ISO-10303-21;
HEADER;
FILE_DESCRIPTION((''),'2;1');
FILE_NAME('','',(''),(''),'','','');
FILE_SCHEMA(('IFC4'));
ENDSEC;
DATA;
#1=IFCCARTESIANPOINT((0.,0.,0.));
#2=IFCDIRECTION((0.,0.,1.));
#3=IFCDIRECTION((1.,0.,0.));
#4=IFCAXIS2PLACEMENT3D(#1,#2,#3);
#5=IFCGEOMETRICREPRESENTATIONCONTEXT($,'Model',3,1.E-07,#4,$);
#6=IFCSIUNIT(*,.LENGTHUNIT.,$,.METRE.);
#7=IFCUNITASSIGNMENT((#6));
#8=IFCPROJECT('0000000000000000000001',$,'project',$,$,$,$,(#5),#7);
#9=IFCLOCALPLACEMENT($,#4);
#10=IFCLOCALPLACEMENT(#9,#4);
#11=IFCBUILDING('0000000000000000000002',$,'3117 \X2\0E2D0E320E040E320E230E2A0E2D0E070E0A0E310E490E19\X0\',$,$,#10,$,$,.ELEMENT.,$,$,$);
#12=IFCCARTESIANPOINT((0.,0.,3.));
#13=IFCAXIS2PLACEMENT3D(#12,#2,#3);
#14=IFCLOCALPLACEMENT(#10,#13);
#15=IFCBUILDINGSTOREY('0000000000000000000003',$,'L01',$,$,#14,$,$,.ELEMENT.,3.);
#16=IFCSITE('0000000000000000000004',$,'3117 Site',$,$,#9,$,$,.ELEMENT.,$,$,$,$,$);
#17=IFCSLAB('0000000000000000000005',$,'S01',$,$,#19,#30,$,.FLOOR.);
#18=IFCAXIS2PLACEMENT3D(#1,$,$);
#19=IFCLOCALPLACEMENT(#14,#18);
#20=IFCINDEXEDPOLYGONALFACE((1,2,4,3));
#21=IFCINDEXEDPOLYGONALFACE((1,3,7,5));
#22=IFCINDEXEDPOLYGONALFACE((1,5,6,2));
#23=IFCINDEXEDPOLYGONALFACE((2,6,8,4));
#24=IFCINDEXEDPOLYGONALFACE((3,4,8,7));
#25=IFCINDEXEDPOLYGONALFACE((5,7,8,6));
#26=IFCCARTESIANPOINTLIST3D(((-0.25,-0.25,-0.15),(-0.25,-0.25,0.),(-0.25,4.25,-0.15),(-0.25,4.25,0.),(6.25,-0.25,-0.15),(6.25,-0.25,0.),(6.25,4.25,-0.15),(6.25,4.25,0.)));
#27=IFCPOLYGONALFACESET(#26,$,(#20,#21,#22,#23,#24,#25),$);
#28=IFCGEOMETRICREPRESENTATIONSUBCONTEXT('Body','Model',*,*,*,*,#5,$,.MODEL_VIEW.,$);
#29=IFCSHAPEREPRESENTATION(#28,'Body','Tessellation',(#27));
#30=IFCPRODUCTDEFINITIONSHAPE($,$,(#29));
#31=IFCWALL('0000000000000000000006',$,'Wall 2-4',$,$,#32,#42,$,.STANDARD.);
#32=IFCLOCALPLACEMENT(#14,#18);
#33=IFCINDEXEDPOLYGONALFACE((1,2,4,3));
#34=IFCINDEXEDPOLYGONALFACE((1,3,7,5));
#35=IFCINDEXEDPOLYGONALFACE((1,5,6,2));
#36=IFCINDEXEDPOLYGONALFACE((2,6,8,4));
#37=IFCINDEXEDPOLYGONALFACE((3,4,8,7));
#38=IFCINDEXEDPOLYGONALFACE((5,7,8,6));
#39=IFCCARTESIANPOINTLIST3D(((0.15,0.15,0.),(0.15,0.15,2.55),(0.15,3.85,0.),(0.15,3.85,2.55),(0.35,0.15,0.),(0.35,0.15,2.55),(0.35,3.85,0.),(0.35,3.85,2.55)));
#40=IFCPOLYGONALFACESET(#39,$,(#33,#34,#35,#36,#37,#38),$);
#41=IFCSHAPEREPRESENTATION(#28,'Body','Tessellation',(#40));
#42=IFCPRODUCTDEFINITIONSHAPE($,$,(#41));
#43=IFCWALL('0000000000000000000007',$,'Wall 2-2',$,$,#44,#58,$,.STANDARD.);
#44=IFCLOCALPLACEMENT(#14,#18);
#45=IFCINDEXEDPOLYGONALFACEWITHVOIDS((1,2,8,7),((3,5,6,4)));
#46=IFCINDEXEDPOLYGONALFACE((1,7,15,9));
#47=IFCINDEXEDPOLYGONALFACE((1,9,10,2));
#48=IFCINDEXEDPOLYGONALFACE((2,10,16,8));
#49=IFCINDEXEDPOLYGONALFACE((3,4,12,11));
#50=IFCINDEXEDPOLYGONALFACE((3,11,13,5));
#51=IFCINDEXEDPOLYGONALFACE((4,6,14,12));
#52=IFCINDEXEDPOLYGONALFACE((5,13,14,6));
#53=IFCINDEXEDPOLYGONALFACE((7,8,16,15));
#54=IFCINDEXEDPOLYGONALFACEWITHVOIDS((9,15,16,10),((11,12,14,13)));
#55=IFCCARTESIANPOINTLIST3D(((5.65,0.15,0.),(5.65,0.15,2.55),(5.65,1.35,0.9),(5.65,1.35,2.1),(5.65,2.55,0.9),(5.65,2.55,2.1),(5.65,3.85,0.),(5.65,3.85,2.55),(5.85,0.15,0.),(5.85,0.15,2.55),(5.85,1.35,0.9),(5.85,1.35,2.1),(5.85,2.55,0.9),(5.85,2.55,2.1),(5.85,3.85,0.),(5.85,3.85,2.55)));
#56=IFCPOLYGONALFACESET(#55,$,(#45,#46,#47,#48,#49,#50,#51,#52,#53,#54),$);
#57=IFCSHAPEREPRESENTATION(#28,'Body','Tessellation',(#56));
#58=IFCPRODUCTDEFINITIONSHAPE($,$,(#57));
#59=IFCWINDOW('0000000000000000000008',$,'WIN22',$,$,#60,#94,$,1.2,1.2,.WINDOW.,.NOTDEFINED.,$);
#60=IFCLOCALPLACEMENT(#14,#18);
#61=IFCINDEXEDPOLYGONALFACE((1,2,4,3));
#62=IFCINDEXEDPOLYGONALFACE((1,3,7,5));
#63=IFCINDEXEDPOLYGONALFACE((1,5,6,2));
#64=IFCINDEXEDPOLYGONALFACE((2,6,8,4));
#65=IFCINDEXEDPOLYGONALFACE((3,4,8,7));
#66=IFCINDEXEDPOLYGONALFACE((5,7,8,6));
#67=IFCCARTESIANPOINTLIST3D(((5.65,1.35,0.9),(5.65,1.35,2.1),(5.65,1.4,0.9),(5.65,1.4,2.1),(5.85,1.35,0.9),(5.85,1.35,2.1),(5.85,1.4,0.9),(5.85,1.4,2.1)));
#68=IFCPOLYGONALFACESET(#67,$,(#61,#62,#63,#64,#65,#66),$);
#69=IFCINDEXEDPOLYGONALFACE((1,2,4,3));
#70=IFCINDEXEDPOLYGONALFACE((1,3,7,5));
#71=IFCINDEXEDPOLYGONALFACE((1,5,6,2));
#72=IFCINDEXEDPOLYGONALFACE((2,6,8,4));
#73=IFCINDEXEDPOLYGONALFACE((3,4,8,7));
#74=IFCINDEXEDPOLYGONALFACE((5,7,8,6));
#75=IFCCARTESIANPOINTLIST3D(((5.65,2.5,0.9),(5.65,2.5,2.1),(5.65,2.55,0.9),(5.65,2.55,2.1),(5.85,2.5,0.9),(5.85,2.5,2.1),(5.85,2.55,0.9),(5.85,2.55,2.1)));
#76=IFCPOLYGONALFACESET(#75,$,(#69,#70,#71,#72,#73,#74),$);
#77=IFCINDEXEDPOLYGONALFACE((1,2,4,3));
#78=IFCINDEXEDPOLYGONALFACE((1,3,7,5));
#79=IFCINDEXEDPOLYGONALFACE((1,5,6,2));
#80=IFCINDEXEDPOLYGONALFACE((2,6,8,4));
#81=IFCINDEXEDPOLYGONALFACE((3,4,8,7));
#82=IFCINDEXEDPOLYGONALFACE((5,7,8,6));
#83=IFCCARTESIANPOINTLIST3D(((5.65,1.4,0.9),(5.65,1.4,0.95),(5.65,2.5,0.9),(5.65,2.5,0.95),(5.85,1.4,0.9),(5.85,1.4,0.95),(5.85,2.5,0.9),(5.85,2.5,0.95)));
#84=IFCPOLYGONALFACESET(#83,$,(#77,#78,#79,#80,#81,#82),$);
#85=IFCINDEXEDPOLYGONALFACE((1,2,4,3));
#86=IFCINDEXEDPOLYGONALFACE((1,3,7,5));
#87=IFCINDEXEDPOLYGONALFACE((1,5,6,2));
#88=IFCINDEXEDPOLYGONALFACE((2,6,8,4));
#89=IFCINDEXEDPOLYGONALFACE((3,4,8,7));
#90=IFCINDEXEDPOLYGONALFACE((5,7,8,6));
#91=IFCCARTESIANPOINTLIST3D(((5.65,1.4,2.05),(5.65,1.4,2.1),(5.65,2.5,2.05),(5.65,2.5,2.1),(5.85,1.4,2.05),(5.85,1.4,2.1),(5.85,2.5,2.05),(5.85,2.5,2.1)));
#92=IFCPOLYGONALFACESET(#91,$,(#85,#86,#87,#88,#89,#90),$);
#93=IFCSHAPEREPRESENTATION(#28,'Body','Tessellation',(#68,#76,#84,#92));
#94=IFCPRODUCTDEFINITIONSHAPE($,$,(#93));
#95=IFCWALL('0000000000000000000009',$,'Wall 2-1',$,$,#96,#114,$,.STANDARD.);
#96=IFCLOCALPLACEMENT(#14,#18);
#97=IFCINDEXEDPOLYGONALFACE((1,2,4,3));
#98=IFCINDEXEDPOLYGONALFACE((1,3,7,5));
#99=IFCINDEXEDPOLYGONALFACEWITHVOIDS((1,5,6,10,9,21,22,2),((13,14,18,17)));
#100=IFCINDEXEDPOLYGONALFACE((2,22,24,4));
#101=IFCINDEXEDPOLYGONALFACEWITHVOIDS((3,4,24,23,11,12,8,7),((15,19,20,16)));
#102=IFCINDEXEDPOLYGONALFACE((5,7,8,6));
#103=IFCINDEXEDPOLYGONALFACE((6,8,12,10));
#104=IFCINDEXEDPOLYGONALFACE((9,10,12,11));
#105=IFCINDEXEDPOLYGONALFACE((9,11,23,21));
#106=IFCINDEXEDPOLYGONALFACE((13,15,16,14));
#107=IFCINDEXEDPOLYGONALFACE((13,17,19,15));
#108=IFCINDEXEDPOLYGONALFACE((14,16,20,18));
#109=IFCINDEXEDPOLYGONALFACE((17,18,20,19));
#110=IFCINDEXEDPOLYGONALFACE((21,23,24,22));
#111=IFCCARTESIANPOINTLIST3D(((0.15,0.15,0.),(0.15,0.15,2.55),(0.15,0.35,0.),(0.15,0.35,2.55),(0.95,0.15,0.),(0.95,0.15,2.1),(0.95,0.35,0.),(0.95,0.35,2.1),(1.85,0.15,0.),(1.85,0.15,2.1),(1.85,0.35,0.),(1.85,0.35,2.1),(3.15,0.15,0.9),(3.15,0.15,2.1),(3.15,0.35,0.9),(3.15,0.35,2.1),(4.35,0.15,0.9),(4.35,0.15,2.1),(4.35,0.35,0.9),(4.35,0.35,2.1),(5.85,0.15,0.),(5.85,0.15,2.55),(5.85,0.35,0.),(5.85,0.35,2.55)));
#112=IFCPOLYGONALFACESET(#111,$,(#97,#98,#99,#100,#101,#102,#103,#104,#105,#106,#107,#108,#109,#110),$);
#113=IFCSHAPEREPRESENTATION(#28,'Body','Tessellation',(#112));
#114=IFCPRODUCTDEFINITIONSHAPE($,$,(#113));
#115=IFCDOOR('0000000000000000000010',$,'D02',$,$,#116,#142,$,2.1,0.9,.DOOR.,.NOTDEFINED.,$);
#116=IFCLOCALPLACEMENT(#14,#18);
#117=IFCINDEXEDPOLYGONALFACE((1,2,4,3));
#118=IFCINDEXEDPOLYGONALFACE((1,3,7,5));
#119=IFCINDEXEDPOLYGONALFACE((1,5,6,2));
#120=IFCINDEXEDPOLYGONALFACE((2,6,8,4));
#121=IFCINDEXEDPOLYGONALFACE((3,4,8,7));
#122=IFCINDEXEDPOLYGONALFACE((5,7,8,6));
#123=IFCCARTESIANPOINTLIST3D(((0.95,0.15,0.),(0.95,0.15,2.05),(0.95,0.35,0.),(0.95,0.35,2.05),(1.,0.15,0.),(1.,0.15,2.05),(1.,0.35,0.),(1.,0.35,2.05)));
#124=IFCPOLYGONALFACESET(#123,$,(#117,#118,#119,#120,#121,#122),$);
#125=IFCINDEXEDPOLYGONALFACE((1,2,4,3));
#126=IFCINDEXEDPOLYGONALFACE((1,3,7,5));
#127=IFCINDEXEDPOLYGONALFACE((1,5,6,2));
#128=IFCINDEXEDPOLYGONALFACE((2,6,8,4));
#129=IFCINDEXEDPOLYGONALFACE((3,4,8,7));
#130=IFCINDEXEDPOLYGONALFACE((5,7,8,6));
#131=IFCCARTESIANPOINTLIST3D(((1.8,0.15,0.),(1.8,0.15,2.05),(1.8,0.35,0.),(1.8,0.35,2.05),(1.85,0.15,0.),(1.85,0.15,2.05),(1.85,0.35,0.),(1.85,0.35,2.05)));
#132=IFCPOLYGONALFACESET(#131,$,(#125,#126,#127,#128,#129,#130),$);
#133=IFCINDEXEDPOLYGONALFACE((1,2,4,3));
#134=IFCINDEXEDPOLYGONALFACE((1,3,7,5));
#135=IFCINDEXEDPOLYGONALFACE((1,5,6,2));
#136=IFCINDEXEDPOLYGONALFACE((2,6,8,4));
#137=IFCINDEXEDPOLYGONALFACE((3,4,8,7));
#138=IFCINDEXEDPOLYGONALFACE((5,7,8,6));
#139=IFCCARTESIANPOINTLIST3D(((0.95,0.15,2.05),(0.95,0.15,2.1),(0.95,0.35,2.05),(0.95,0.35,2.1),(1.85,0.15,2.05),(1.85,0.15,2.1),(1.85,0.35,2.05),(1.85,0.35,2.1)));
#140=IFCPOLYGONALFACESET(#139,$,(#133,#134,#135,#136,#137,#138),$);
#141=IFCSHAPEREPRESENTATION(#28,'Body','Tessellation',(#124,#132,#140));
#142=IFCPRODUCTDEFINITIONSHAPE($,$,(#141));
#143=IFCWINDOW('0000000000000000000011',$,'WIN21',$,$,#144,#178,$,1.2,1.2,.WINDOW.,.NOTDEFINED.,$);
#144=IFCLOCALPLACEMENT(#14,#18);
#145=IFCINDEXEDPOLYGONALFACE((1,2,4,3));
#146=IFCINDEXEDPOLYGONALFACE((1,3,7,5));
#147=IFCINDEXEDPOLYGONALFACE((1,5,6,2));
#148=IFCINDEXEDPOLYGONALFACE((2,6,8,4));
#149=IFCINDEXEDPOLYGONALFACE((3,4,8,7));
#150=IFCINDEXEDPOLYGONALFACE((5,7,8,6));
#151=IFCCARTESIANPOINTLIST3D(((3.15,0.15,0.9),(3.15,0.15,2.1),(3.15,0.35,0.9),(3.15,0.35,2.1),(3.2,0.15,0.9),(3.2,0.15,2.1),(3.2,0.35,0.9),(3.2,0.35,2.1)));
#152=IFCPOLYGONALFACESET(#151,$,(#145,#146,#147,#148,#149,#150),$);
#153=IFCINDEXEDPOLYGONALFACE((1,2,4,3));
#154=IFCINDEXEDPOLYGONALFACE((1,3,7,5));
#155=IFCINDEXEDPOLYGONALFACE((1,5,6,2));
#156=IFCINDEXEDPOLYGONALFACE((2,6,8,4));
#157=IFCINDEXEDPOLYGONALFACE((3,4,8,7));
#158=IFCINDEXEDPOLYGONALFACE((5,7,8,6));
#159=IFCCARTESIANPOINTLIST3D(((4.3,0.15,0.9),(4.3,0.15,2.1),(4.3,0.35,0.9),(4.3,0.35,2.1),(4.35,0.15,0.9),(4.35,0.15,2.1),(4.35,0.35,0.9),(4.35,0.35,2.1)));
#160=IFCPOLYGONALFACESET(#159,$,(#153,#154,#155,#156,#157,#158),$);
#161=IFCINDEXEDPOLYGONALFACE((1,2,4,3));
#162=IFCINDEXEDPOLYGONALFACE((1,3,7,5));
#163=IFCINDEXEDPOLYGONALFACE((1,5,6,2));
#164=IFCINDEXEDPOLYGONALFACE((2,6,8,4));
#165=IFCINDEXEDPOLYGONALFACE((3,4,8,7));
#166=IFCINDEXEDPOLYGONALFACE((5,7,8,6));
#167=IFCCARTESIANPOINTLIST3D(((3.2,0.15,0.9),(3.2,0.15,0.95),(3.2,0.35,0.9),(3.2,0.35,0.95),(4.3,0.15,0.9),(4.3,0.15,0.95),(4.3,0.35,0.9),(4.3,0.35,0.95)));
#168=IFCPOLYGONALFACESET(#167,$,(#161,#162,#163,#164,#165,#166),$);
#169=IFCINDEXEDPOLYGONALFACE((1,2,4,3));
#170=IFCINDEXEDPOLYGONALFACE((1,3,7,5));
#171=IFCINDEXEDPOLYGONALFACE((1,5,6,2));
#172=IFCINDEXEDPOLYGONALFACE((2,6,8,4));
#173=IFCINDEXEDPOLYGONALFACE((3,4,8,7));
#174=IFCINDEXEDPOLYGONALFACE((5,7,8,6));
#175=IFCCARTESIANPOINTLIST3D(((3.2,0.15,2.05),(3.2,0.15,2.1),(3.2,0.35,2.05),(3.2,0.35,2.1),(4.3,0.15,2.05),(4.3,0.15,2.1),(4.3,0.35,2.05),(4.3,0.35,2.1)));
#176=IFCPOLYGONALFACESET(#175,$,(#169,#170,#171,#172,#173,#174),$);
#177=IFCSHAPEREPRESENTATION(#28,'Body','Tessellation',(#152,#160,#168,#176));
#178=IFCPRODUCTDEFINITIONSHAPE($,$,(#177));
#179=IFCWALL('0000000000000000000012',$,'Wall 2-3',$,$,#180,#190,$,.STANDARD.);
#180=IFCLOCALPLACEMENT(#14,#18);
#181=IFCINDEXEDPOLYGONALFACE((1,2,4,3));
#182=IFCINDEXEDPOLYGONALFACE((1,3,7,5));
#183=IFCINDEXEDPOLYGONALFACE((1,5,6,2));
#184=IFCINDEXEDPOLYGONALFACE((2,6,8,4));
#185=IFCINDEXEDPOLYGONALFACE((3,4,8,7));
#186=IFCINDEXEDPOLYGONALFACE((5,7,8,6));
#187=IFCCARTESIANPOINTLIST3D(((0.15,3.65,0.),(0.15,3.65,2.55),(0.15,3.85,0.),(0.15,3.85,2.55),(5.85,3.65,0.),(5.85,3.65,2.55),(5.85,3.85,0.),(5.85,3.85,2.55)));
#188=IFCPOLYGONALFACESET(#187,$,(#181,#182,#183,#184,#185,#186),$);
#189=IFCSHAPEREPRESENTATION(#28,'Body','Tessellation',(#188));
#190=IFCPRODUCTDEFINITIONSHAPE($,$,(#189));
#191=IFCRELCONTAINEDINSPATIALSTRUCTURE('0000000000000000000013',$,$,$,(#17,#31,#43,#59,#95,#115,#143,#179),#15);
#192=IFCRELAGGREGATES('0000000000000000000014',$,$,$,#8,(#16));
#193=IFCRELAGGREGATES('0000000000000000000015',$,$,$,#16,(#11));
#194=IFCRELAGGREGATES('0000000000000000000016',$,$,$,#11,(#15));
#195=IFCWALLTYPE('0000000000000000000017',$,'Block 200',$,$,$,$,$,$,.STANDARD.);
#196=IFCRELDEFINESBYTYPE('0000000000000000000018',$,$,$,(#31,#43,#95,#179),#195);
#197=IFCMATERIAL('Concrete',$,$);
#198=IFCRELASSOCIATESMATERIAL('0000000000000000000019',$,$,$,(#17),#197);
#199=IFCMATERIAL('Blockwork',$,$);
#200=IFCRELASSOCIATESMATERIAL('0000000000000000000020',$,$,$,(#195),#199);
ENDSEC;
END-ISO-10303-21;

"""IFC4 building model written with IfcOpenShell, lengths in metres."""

from ifc_helpers import new_model, si_unit, frame, origin_with_axes, place, context, subcontext, project, spatial, polyline, outline, extrude, material, type_object, element, fill, save


model = new_model("IFC4")

# Units and contexts
model_context = context("Model", 3, precision=1e-07, world=origin_with_axes())
body_context = subcontext(model_context, "Body", "Model", "MODEL_VIEW")
ifc_project = project(units=[si_unit("LENGTHUNIT", "METRE")], contexts=[model_context])

# Site, building, storey
site_placement = place(None, origin_with_axes())
site = spatial("IfcSite", under=ifc_project, at=site_placement, Name="3117 Site", CompositionType="ELEMENT")
building_placement = place(site_placement, origin_with_axes())
building = spatial("IfcBuilding", under=site, at=building_placement, Name="3117 อาคารสองชั้น", CompositionType="ELEMENT")
storey_placement = place(building_placement, frame((0.0, 0.0, 3.0), z_axis=(0.0, 0.0, 1.0), x_axis=(1.0, 0.0, 0.0)))
storey = spatial("IfcBuildingStorey", under=building, at=storey_placement, Name="L01", CompositionType="ELEMENT", Elevation=3.0)

# Slab
ifc_material_1 = material(Name="Concrete")
slab_placement = place(storey_placement, frame((0.0, 0.0, -0.15), z_axis=(0.0, 0.0, 1.0), x_axis=(1.0, 0.0, 0.0)))
element("IfcSlab", 1, at=slab_placement, inside=storey, material=ifc_material_1, Name="S01", PredefinedType="FLOOR", context=body_context, shape_type="SweptSolid", body=[
    extrude(outline(polyline([(-0.25, -0.25), (6.25, -0.25), (6.25, 4.25), (-0.25, 4.25), (-0.25, -0.25)])), origin_with_axes(), (0.0, 0.0, 1.0), 0.15),
])

# Wall
ifc_material_2 = material(Name="Blockwork")
wall_type = type_object("IfcWallType", Name="Block 200", PredefinedType="STANDARD", material=ifc_material_2)
wall_1_placement = place(storey_placement, frame((0.15, 3.85, 0.0), z_axis=(0.0, 0.0, 1.0), x_axis=(0.0, -1.0, 0.0)))
element("IfcWall", 2, at=wall_1_placement, inside=storey, type_object=wall_type, Name="Wall 2-4", PredefinedType="STANDARD", context=body_context, shape_type="SweptSolid", body=[
    extrude(outline(polyline([(0.0, 0.0), (3.7, 0.0), (3.7, 0.2), (0.0, 0.2), (0.0, 0.0)])), origin_with_axes(), (0.0, 0.0, 1.0), 2.55),
])

# Wall, opening, window
wall_2_placement = place(storey_placement, frame((5.85, 0.15, 0.0), z_axis=(0.0, 0.0, 1.0), x_axis=(0.0, 1.0, 0.0)))
wall_2 = element("IfcWall", 3, at=wall_2_placement, inside=storey, type_object=wall_type, Name="Wall 2-2", PredefinedType="STANDARD", context=body_context, shape_type="SweptSolid", body=[
    extrude(outline(polyline([(0.0, 0.0), (3.7, 0.0), (3.7, 0.2), (0.0, 0.2), (0.0, 0.0)])), origin_with_axes(), (0.0, 0.0, 1.0), 2.55),
])
opening_1_placement = place(wall_2_placement, frame((1.2, 0.0, 0.9), z_axis=(0.0, 0.0, 1.0), x_axis=(1.0, 0.0, 0.0)))
opening_1 = element("IfcOpeningElement", 4, at=opening_1_placement, cuts=wall_2, PredefinedType="OPENING", context=body_context, shape_type="SweptSolid", body=[
    extrude(outline(polyline([(0.0, 0.0), (1.2, 0.0), (1.2, 0.2), (0.0, 0.2), (0.0, 0.0)])), origin_with_axes(), (0.0, 0.0, 1.0), 1.2),
])
window_1_placement = place(opening_1_placement, frame((0.0, 0.0, 0.0), z_axis=(0.0, 0.0, 1.0), x_axis=(1.0, 0.0, 0.0)))
window_1 = element("IfcWindow", 5, at=window_1_placement, inside=storey, Name="WIN22", OverallHeight=1.2, OverallWidth=1.2, PartitioningType="NOTDEFINED", PredefinedType="WINDOW", context=body_context, shape_type="SweptSolid", body=[
    extrude(outline(polyline([(0.0, 0.0), (0.05, 0.0), (0.05, 0.2), (0.0, 0.2), (0.0, 0.0)])), origin_with_axes(), (0.0, 0.0, 1.0), 1.2),
    extrude(outline(polyline([(0.0, 0.0), (0.05, 0.0), (0.05, 0.2), (0.0, 0.2), (0.0, 0.0)])), frame((1.15, 0.0, 0.0), z_axis=(0.0, 0.0, 1.0), x_axis=(1.0, 0.0, 0.0)), (0.0, 0.0, 1.0), 1.2),
    extrude(outline(polyline([(0.0, 0.0), (1.1, 0.0), (1.1, 0.2), (0.0, 0.2), (0.0, 0.0)])), frame((0.05, 0.0, 0.0), z_axis=(0.0, 0.0, 1.0), x_axis=(1.0, 0.0, 0.0)), (0.0, 0.0, 1.0), 0.05),
    extrude(outline(polyline([(0.0, 0.0), (1.1, 0.0), (1.1, 0.2), (0.0, 0.2), (0.0, 0.0)])), frame((0.05, 0.0, 1.15), z_axis=(0.0, 0.0, 1.0), x_axis=(1.0, 0.0, 0.0)), (0.0, 0.0, 1.0), 0.05),
])
fill(opening_1, window_1)

# Wall, openings, door, window
wall_3_placement = place(storey_placement, frame((0.15, 0.15, 0.0), z_axis=(0.0, 0.0, 1.0), x_axis=(1.0, 0.0, 0.0)))
wall_3 = element("IfcWall", 6, at=wall_3_placement, inside=storey, type_object=wall_type, Name="Wall 2-1", PredefinedType="STANDARD", context=body_context, shape_type="SweptSolid", body=[
    extrude(outline(polyline([(0.0, 0.0), (5.7, 0.0), (5.7, 0.2), (0.0, 0.2), (0.0, 0.0)])), origin_with_axes(), (0.0, 0.0, 1.0), 2.55),
])
opening_2_placement = place(wall_3_placement, frame((0.8, 0.0, 0.0), z_axis=(0.0, 0.0, 1.0), x_axis=(1.0, 0.0, 0.0)))
opening_2 = element("IfcOpeningElement", 7, at=opening_2_placement, cuts=wall_3, PredefinedType="OPENING", context=body_context, shape_type="SweptSolid", body=[
    extrude(outline(polyline([(0.0, 0.0), (0.9, 0.0), (0.9, 0.2), (0.0, 0.2), (0.0, 0.0)])), origin_with_axes(), (0.0, 0.0, 1.0), 2.1),
])
opening_3_placement = place(wall_3_placement, frame((3.0, 0.0, 0.9), z_axis=(0.0, 0.0, 1.0), x_axis=(1.0, 0.0, 0.0)))
opening_3 = element("IfcOpeningElement", 8, at=opening_3_placement, cuts=wall_3, PredefinedType="OPENING", context=body_context, shape_type="SweptSolid", body=[
    extrude(outline(polyline([(0.0, 0.0), (1.2, 0.0), (1.2, 0.2), (0.0, 0.2), (0.0, 0.0)])), origin_with_axes(), (0.0, 0.0, 1.0), 1.2),
])
door_placement = place(opening_2_placement, frame((0.0, 0.0, 0.0), z_axis=(0.0, 0.0, 1.0), x_axis=(1.0, 0.0, 0.0)))
door = element("IfcDoor", 9, at=door_placement, inside=storey, Name="D02", OperationType="NOTDEFINED", OverallHeight=2.1, OverallWidth=0.9, PredefinedType="DOOR", context=body_context, shape_type="SweptSolid", body=[
    extrude(outline(polyline([(0.0, 0.0), (0.05, 0.0), (0.05, 0.2), (0.0, 0.2), (0.0, 0.0)])), origin_with_axes(), (0.0, 0.0, 1.0), 2.05),
    extrude(outline(polyline([(0.0, 0.0), (0.05, 0.0), (0.05, 0.2), (0.0, 0.2), (0.0, 0.0)])), frame((0.85, 0.0, 0.0), z_axis=(0.0, 0.0, 1.0), x_axis=(1.0, 0.0, 0.0)), (0.0, 0.0, 1.0), 2.05),
    extrude(outline(polyline([(0.0, 0.0), (0.9, 0.0), (0.9, 0.2), (0.0, 0.2), (0.0, 0.0)])), frame((0.0, 0.0, 2.05), z_axis=(0.0, 0.0, 1.0), x_axis=(1.0, 0.0, 0.0)), (0.0, 0.0, 1.0), 0.05),
])
fill(opening_2, door)
window_2_placement = place(opening_3_placement, frame((0.0, 0.0, 0.0), z_axis=(0.0, 0.0, 1.0), x_axis=(1.0, 0.0, 0.0)))
window_2 = element("IfcWindow", 10, at=window_2_placement, inside=storey, Name="WIN21", OverallHeight=1.2, OverallWidth=1.2, PartitioningType="NOTDEFINED", PredefinedType="WINDOW", context=body_context, shape_type="SweptSolid", body=[
    extrude(outline(polyline([(0.0, 0.0), (0.05, 0.0), (0.05, 0.2), (0.0, 0.2), (0.0, 0.0)])), origin_with_axes(), (0.0, 0.0, 1.0), 1.2),
    extrude(outline(polyline([(0.0, 0.0), (0.05, 0.0), (0.05, 0.2), (0.0, 0.2), (0.0, 0.0)])), frame((1.15, 0.0, 0.0), z_axis=(0.0, 0.0, 1.0), x_axis=(1.0, 0.0, 0.0)), (0.0, 0.0, 1.0), 1.2),
    extrude(outline(polyline([(0.0, 0.0), (1.1, 0.0), (1.1, 0.2), (0.0, 0.2), (0.0, 0.0)])), frame((0.05, 0.0, 0.0), z_axis=(0.0, 0.0, 1.0), x_axis=(1.0, 0.0, 0.0)), (0.0, 0.0, 1.0), 0.05),
    extrude(outline(polyline([(0.0, 0.0), (1.1, 0.0), (1.1, 0.2), (0.0, 0.2), (0.0, 0.0)])), frame((0.05, 0.0, 1.15), z_axis=(0.0, 0.0, 1.0), x_axis=(1.0, 0.0, 0.0)), (0.0, 0.0, 1.0), 0.05),
])
fill(opening_3, window_2)

# Wall
wall_4_placement = place(storey_placement, frame((5.85, 3.85, 0.0), z_axis=(0.0, 0.0, 1.0), x_axis=(-1.0, 0.0, 0.0)))
element("IfcWall", 11, at=wall_4_placement, inside=storey, type_object=wall_type, Name="Wall 2-3", PredefinedType="STANDARD", context=body_context, shape_type="SweptSolid", body=[
    extrude(outline(polyline([(0.0, 0.0), (5.7, 0.0), (5.7, 0.2), (0.0, 0.2), (0.0, 0.0)])), origin_with_axes(), (0.0, 0.0, 1.0), 2.55),
])

save(model, "model.ifc")
